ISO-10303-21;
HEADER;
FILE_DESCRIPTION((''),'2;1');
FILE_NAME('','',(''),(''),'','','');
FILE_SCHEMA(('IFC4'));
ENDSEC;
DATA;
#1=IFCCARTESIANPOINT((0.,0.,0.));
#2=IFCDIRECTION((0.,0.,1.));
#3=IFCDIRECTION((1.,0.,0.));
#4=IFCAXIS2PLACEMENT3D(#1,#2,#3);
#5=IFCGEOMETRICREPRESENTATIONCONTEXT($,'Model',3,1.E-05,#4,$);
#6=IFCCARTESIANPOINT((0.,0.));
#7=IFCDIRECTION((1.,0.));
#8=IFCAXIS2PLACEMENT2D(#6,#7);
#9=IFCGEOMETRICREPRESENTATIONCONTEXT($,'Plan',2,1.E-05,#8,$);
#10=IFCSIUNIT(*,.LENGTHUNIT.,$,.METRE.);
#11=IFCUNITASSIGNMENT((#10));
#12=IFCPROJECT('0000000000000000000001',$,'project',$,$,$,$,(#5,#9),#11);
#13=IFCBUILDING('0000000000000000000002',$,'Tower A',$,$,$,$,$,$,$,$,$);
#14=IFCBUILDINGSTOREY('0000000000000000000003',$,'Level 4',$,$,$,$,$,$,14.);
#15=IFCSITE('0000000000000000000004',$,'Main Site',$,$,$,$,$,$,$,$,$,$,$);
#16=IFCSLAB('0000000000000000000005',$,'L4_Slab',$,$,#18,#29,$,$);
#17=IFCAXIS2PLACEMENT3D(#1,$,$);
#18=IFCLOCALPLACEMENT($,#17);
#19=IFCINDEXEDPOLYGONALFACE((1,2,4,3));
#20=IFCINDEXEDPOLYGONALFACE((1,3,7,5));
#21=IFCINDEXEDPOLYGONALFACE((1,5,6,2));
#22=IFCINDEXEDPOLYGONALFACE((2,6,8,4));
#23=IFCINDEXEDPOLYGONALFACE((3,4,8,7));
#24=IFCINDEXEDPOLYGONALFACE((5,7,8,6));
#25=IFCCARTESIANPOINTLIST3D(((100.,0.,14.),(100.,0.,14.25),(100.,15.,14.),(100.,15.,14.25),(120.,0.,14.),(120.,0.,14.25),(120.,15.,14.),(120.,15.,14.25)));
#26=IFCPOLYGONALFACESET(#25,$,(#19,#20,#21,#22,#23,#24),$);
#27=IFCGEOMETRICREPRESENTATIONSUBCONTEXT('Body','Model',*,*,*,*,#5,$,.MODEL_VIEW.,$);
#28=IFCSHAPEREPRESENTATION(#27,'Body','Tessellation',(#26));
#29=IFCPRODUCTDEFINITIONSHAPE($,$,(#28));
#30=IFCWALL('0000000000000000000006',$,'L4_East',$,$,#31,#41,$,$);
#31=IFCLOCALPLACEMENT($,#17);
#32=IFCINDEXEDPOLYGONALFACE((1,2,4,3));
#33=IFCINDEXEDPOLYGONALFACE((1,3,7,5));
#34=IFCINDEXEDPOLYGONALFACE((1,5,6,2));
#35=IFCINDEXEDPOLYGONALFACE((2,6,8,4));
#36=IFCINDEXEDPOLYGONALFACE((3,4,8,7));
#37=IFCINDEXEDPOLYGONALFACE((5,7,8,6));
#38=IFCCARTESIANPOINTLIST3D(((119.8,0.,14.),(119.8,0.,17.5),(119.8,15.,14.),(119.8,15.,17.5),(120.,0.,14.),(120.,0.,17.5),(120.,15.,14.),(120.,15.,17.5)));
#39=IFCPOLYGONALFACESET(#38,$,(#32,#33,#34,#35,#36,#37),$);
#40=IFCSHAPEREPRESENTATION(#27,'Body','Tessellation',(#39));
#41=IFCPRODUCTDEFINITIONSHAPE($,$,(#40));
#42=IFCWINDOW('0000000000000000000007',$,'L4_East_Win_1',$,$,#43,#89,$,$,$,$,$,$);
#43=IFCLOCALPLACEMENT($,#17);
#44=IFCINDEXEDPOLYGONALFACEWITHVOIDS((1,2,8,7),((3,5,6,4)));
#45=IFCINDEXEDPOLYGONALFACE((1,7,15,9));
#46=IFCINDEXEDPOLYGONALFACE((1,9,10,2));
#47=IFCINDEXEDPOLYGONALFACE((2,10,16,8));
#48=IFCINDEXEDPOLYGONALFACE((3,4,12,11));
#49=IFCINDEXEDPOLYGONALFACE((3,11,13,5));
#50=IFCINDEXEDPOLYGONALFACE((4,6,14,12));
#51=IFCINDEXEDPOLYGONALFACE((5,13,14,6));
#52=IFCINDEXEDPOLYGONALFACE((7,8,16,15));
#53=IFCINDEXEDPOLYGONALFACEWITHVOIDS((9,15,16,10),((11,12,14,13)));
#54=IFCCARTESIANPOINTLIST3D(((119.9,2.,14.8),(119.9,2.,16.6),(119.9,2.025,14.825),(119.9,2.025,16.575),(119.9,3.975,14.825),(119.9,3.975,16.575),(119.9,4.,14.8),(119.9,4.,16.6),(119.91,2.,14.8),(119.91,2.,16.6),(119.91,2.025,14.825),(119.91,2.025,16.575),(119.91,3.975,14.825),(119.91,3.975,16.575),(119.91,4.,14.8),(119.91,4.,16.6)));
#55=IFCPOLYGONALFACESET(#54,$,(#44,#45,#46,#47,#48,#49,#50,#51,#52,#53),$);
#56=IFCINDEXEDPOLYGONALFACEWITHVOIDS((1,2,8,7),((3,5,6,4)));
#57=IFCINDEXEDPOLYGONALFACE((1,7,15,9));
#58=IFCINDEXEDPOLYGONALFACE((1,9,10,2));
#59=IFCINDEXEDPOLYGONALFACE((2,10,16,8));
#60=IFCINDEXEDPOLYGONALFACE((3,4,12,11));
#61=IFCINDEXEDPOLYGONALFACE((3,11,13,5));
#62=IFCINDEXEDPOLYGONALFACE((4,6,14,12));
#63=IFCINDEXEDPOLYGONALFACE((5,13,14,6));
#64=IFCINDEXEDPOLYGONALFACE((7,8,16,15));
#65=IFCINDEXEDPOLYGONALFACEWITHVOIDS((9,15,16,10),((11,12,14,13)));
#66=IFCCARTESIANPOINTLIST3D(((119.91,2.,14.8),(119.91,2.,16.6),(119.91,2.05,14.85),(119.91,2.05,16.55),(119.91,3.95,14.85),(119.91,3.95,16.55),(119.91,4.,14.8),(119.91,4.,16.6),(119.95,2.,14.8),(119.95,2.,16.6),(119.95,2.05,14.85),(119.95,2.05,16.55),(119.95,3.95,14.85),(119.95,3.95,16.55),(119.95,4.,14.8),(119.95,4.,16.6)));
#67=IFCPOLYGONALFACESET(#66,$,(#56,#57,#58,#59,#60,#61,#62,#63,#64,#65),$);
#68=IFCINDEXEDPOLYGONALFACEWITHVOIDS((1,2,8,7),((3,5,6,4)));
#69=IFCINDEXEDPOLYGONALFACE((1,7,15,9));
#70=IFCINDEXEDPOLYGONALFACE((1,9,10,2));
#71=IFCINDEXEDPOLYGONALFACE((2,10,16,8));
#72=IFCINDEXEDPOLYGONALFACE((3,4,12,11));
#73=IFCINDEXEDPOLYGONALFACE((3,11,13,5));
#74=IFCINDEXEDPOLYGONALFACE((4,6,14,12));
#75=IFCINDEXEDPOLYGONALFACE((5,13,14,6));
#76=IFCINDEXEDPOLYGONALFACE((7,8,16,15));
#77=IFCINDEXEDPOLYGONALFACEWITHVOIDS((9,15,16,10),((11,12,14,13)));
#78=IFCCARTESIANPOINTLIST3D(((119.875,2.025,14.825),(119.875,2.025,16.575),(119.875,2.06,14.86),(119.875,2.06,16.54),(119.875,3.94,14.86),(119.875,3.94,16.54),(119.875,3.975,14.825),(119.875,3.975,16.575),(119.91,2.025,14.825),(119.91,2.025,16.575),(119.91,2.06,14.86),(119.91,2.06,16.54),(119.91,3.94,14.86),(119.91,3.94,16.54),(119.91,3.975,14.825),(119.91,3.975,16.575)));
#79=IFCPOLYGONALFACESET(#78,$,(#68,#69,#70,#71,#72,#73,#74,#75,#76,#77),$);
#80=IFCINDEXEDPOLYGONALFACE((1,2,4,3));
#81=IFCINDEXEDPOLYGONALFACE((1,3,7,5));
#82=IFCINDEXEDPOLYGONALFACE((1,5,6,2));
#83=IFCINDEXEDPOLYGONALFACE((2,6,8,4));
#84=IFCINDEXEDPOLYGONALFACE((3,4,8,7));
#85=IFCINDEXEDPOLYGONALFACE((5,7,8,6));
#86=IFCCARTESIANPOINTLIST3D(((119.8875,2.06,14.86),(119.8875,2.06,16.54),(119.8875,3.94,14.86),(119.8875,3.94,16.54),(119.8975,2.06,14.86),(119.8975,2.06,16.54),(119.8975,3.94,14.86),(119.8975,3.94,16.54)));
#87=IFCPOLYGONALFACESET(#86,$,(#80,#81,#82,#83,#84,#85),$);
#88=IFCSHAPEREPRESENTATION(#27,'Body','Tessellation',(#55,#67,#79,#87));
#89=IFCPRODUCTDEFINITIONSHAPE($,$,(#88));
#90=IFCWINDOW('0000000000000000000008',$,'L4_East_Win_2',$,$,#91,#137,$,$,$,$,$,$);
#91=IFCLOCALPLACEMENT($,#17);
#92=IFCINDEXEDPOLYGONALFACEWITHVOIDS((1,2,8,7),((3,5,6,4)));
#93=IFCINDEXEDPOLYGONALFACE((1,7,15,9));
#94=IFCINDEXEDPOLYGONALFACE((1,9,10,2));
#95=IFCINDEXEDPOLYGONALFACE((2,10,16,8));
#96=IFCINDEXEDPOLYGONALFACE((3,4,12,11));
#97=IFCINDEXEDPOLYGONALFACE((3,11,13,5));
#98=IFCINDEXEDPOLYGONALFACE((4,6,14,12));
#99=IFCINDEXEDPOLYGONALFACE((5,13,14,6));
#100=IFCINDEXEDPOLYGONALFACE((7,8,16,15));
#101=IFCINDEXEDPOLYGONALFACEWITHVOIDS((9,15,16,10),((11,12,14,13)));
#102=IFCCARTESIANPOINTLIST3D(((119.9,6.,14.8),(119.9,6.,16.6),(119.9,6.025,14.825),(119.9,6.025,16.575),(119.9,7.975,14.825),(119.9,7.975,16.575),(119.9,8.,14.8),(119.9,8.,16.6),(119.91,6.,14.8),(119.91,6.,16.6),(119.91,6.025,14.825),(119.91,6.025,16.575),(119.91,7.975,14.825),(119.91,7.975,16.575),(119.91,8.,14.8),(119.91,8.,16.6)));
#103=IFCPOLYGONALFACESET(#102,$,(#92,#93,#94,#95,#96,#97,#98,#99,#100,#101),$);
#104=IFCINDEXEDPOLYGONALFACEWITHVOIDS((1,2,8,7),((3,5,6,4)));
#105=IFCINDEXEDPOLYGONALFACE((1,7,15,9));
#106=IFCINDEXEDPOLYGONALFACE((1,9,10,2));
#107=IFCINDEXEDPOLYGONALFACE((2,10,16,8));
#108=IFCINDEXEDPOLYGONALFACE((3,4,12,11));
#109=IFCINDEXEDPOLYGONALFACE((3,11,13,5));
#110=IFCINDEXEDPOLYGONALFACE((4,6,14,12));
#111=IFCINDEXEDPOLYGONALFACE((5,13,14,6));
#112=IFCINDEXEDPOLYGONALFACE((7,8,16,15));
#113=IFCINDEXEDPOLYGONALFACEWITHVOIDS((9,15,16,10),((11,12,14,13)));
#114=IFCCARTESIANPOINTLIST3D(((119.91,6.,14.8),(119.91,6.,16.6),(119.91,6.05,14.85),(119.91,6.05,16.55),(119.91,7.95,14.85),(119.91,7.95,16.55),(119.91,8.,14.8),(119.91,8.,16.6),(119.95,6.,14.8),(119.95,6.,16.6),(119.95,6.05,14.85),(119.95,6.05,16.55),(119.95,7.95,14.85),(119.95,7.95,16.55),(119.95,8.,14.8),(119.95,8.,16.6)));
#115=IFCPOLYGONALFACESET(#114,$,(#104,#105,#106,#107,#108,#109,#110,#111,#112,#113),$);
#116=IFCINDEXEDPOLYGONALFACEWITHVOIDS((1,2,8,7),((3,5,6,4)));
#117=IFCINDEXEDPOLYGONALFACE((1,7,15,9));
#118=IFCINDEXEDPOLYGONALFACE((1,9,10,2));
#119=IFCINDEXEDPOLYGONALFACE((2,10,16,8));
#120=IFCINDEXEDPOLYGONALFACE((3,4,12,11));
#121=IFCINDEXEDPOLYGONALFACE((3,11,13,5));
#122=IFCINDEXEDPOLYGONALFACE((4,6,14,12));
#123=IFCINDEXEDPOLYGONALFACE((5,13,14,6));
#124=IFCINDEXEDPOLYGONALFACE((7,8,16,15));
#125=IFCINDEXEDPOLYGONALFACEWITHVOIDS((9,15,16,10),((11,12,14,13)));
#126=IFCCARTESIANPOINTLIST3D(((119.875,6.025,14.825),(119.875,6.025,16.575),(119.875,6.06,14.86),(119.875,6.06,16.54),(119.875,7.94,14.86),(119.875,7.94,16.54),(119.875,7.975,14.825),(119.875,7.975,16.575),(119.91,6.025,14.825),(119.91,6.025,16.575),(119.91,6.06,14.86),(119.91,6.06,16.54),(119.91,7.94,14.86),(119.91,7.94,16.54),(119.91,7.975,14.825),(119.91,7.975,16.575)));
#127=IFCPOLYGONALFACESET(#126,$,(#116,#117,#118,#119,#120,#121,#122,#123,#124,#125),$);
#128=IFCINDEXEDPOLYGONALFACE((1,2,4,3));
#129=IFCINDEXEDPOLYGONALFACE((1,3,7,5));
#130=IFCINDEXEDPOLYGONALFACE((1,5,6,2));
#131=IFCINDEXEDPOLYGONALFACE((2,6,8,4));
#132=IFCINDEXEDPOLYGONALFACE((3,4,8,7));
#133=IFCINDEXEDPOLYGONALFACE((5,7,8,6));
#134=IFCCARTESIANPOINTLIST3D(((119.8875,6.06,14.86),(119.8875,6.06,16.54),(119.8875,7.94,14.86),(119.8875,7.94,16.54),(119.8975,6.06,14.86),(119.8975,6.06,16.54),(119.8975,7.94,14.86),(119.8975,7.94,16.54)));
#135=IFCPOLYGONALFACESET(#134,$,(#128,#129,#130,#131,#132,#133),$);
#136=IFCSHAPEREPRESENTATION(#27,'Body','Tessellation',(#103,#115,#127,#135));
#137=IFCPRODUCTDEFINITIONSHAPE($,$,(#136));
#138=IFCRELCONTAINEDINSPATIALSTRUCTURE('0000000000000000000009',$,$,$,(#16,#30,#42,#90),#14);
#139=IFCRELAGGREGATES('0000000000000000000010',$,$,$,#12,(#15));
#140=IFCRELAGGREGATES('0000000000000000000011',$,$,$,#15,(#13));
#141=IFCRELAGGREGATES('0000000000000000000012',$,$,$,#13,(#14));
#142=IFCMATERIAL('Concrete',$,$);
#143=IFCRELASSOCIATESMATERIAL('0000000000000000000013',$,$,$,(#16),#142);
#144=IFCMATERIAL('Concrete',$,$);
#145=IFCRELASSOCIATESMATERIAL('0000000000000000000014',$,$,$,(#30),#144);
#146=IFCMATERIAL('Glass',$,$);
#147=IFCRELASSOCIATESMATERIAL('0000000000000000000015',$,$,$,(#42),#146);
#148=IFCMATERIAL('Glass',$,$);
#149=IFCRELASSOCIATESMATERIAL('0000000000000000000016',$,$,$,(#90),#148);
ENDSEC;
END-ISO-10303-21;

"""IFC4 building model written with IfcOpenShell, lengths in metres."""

from ifc_helpers import new_model, si_unit, frame, origin_with_axes, origin_2d_with_axis, place, context, subcontext, project, spatial, line, indexed_curve, outline, extrude, material, element, fill, save


model = new_model("IFC4")

# Units and contexts
model_context = context("Model", 3, precision=1e-05, world=origin_with_axes())
plan_context = context("Plan", 2, precision=1e-05, world=origin_2d_with_axis())
body_context = subcontext(model_context, "Body", "Model", "MODEL_VIEW")
ifc_project = project(units=[si_unit("LENGTHUNIT", "METRE")], contexts=[model_context, plan_context])

# Site, building, storey
site = spatial("IfcSite", under=ifc_project, Name="Main Site")
building = spatial("IfcBuilding", under=site, Name="Tower A")
storey = spatial("IfcBuildingStorey", under=building, Name="Level 4", Elevation=14.0)

# Slab
ifc_material_1 = material(Name="Concrete")
slab_placement = place(None, frame((100.0, 0.0, 14.0), z_axis=(0.0, 0.0, 1.0), x_axis=(1.0, 0.0, 0.0)))
element("IfcSlab", 1, at=slab_placement, inside=storey, material=ifc_material_1, Name="L4_Slab", context=body_context, shape_type="SweptSolid", body=[
    extrude(outline(indexed_curve([(0.0, 0.0), (20.0, 0.0), (20.0, 15.0), (0.0, 15.0)])), None, (0.0, 0.0, 1.0), 0.25),
])

# Wall, openings, windows
ifc_material_2 = material(Name="Concrete")
wall_1_placement = place(None, frame((120.0, 0.0, 14.0), z_axis=(0.0, 0.0, 1.0), x_axis=(0.0, 1.0, 0.0)))
wall_1 = element("IfcWall", 2, at=wall_1_placement, inside=storey, material=ifc_material_2, Name="L4_East", context=body_context, shape_type="SweptSolid", body=[
    extrude(outline(indexed_curve([(0.0, 0.0), (0.0, 0.2), (15.0, 0.2), (15.0, 0.0), (0.0, 0.0)], self_intersect=False)), origin_with_axes(), (0.0, 0.0, 1.0), 3.5),
])
opening_1_placement = place(wall_1_placement, frame((2.0, 0.0, 0.8), z_axis=(0.0, 0.0, 1.0), x_axis=(0.0, -1.0, 0.0)))
opening_1 = element("IfcOpeningElement", 3, at=opening_1_placement, cuts=wall_1, context=body_context, shape_type="SweptSolid", body=[
    extrude(outline(indexed_curve([(0.0, 0.0), (0.0, 0.25), (2.0, 0.25), (2.0, 0.0), (0.0, 0.0)], self_intersect=False)), origin_with_axes(), (0.0, 0.0, 1.0), 1.8),
])
opening_2_placement = place(wall_1_placement, frame((6.0, 0.0, 0.8), z_axis=(0.0, 0.0, 1.0), x_axis=(0.0, -1.0, 0.0)))
opening_2 = element("IfcOpeningElement", 4, at=opening_2_placement, cuts=wall_1, context=body_context, shape_type="SweptSolid", body=[
    extrude(outline(indexed_curve([(0.0, 0.0), (0.0, 0.25), (2.0, 0.25), (2.0, 0.0), (0.0, 0.0)], self_intersect=False)), origin_with_axes(), (0.0, 0.0, 1.0), 1.8),
])
ifc_material_3 = material(Name="Glass")
window_1_placement = place(None, frame((120.0, 2.0, 14.8), z_axis=(0.0, 0.0, 1.0), x_axis=(0.0, 1.0, 0.0)))
window_1 = element("IfcWindow", 5, at=window_1_placement, inside=storey, material=ifc_material_3, Name="L4_East_Win_1", context=body_context, shape_type="SweptSolid", body=[
    extrude(outline(indexed_curve([(0.0, 0.0), (2.0, 0.0), (2.0, 1.8), (0.0, 1.8)], segments=[line(1, 2, 3, 4, 1)]), holes=[indexed_curve([(0.025, 0.025), (1.975, 0.025), (1.975, 1.775), (0.025, 1.775)], segments=[line(1, 2, 3, 4, 1)])]), frame((0.0, 0.09, 0.0), z_axis=(0.0, -1.0, 0.0), x_axis=(1.0, 0.0, 0.0)), (0.0, 0.0, -1.0), 0.01),
    extrude(outline(indexed_curve([(0.0, 0.0), (2.0, 0.0), (2.0, 1.8), (0.0, 1.8)], segments=[line(1, 2, 3, 4, 1)]), holes=[indexed_curve([(0.05, 0.05), (1.95, 0.05), (1.95, 1.75), (0.05, 1.75)], segments=[line(1, 2, 3, 4, 1)])]), frame((0.0, 0.05, 0.0), z_axis=(0.0, -1.0, 0.0), x_axis=(1.0, 0.0, 0.0)), (0.0, 0.0, -1.0), 0.04),
    extrude(outline(indexed_curve([(0.0, 0.0), (1.95, 0.0), (1.95, 1.75), (0.0, 1.75)], segments=[line(1, 2, 3, 4, 1)]), holes=[indexed_curve([(0.035, 0.035), (1.915, 0.035), (1.915, 1.715), (0.035, 1.715)], segments=[line(1, 2, 3, 4, 1)])]), frame((0.025, 0.09, 0.025), z_axis=(0.0, -1.0, 0.0), x_axis=(1.0, 0.0, 0.0)), (0.0, 0.0, -1.0), 0.035),
    extrude(outline(indexed_curve([(0.035, 0.035), (1.915, 0.035), (1.915, 1.715), (0.035, 1.715)], segments=[line(1, 2, 3, 4, 1)])), frame((0.025, 0.1025, 0.025), z_axis=(0.0, -1.0, 0.0), x_axis=(1.0, 0.0, 0.0)), (0.0, 0.0, -1.0), 0.01),
])
fill(opening_1, window_1)
ifc_material_4 = material(Name="Glass")
window_2_placement = place(None, frame((120.0, 6.0, 14.8), z_axis=(0.0, 0.0, 1.0), x_axis=(0.0, 1.0, 0.0)))
window_2 = element("IfcWindow", 6, at=window_2_placement, inside=storey, material=ifc_material_4, Name="L4_East_Win_2", context=body_context, shape_type="SweptSolid", body=[
    extrude(outline(indexed_curve([(0.0, 0.0), (2.0, 0.0), (2.0, 1.8), (0.0, 1.8)], segments=[line(1, 2, 3, 4, 1)]), holes=[indexed_curve([(0.025, 0.025), (1.975, 0.025), (1.975, 1.775), (0.025, 1.775)], segments=[line(1, 2, 3, 4, 1)])]), frame((0.0, 0.09, 0.0), z_axis=(0.0, -1.0, 0.0), x_axis=(1.0, 0.0, 0.0)), (0.0, 0.0, -1.0), 0.01),
    extrude(outline(indexed_curve([(0.0, 0.0), (2.0, 0.0), (2.0, 1.8), (0.0, 1.8)], segments=[line(1, 2, 3, 4, 1)]), holes=[indexed_curve([(0.05, 0.05), (1.95, 0.05), (1.95, 1.75), (0.05, 1.75)], segments=[line(1, 2, 3, 4, 1)])]), frame((0.0, 0.05, 0.0), z_axis=(0.0, -1.0, 0.0), x_axis=(1.0, 0.0, 0.0)), (0.0, 0.0, -1.0), 0.04),
    extrude(outline(indexed_curve([(0.0, 0.0), (1.95, 0.0), (1.95, 1.75), (0.0, 1.75)], segments=[line(1, 2, 3, 4, 1)]), holes=[indexed_curve([(0.035, 0.035), (1.915, 0.035), (1.915, 1.715), (0.035, 1.715)], segments=[line(1, 2, 3, 4, 1)])]), frame((0.025, 0.09, 0.025), z_axis=(0.0, -1.0, 0.0), x_axis=(1.0, 0.0, 0.0)), (0.0, 0.0, -1.0), 0.035),
    extrude(outline(indexed_curve([(0.035, 0.035), (1.915, 0.035), (1.915, 1.715), (0.035, 1.715)], segments=[line(1, 2, 3, 4, 1)])), frame((0.025, 0.1025, 0.025), z_axis=(0.0, -1.0, 0.0), x_axis=(1.0, 0.0, 0.0)), (0.0, 0.0, -1.0), 0.01),
])
fill(opening_2, window_2)

save(model, "model.ifc")
